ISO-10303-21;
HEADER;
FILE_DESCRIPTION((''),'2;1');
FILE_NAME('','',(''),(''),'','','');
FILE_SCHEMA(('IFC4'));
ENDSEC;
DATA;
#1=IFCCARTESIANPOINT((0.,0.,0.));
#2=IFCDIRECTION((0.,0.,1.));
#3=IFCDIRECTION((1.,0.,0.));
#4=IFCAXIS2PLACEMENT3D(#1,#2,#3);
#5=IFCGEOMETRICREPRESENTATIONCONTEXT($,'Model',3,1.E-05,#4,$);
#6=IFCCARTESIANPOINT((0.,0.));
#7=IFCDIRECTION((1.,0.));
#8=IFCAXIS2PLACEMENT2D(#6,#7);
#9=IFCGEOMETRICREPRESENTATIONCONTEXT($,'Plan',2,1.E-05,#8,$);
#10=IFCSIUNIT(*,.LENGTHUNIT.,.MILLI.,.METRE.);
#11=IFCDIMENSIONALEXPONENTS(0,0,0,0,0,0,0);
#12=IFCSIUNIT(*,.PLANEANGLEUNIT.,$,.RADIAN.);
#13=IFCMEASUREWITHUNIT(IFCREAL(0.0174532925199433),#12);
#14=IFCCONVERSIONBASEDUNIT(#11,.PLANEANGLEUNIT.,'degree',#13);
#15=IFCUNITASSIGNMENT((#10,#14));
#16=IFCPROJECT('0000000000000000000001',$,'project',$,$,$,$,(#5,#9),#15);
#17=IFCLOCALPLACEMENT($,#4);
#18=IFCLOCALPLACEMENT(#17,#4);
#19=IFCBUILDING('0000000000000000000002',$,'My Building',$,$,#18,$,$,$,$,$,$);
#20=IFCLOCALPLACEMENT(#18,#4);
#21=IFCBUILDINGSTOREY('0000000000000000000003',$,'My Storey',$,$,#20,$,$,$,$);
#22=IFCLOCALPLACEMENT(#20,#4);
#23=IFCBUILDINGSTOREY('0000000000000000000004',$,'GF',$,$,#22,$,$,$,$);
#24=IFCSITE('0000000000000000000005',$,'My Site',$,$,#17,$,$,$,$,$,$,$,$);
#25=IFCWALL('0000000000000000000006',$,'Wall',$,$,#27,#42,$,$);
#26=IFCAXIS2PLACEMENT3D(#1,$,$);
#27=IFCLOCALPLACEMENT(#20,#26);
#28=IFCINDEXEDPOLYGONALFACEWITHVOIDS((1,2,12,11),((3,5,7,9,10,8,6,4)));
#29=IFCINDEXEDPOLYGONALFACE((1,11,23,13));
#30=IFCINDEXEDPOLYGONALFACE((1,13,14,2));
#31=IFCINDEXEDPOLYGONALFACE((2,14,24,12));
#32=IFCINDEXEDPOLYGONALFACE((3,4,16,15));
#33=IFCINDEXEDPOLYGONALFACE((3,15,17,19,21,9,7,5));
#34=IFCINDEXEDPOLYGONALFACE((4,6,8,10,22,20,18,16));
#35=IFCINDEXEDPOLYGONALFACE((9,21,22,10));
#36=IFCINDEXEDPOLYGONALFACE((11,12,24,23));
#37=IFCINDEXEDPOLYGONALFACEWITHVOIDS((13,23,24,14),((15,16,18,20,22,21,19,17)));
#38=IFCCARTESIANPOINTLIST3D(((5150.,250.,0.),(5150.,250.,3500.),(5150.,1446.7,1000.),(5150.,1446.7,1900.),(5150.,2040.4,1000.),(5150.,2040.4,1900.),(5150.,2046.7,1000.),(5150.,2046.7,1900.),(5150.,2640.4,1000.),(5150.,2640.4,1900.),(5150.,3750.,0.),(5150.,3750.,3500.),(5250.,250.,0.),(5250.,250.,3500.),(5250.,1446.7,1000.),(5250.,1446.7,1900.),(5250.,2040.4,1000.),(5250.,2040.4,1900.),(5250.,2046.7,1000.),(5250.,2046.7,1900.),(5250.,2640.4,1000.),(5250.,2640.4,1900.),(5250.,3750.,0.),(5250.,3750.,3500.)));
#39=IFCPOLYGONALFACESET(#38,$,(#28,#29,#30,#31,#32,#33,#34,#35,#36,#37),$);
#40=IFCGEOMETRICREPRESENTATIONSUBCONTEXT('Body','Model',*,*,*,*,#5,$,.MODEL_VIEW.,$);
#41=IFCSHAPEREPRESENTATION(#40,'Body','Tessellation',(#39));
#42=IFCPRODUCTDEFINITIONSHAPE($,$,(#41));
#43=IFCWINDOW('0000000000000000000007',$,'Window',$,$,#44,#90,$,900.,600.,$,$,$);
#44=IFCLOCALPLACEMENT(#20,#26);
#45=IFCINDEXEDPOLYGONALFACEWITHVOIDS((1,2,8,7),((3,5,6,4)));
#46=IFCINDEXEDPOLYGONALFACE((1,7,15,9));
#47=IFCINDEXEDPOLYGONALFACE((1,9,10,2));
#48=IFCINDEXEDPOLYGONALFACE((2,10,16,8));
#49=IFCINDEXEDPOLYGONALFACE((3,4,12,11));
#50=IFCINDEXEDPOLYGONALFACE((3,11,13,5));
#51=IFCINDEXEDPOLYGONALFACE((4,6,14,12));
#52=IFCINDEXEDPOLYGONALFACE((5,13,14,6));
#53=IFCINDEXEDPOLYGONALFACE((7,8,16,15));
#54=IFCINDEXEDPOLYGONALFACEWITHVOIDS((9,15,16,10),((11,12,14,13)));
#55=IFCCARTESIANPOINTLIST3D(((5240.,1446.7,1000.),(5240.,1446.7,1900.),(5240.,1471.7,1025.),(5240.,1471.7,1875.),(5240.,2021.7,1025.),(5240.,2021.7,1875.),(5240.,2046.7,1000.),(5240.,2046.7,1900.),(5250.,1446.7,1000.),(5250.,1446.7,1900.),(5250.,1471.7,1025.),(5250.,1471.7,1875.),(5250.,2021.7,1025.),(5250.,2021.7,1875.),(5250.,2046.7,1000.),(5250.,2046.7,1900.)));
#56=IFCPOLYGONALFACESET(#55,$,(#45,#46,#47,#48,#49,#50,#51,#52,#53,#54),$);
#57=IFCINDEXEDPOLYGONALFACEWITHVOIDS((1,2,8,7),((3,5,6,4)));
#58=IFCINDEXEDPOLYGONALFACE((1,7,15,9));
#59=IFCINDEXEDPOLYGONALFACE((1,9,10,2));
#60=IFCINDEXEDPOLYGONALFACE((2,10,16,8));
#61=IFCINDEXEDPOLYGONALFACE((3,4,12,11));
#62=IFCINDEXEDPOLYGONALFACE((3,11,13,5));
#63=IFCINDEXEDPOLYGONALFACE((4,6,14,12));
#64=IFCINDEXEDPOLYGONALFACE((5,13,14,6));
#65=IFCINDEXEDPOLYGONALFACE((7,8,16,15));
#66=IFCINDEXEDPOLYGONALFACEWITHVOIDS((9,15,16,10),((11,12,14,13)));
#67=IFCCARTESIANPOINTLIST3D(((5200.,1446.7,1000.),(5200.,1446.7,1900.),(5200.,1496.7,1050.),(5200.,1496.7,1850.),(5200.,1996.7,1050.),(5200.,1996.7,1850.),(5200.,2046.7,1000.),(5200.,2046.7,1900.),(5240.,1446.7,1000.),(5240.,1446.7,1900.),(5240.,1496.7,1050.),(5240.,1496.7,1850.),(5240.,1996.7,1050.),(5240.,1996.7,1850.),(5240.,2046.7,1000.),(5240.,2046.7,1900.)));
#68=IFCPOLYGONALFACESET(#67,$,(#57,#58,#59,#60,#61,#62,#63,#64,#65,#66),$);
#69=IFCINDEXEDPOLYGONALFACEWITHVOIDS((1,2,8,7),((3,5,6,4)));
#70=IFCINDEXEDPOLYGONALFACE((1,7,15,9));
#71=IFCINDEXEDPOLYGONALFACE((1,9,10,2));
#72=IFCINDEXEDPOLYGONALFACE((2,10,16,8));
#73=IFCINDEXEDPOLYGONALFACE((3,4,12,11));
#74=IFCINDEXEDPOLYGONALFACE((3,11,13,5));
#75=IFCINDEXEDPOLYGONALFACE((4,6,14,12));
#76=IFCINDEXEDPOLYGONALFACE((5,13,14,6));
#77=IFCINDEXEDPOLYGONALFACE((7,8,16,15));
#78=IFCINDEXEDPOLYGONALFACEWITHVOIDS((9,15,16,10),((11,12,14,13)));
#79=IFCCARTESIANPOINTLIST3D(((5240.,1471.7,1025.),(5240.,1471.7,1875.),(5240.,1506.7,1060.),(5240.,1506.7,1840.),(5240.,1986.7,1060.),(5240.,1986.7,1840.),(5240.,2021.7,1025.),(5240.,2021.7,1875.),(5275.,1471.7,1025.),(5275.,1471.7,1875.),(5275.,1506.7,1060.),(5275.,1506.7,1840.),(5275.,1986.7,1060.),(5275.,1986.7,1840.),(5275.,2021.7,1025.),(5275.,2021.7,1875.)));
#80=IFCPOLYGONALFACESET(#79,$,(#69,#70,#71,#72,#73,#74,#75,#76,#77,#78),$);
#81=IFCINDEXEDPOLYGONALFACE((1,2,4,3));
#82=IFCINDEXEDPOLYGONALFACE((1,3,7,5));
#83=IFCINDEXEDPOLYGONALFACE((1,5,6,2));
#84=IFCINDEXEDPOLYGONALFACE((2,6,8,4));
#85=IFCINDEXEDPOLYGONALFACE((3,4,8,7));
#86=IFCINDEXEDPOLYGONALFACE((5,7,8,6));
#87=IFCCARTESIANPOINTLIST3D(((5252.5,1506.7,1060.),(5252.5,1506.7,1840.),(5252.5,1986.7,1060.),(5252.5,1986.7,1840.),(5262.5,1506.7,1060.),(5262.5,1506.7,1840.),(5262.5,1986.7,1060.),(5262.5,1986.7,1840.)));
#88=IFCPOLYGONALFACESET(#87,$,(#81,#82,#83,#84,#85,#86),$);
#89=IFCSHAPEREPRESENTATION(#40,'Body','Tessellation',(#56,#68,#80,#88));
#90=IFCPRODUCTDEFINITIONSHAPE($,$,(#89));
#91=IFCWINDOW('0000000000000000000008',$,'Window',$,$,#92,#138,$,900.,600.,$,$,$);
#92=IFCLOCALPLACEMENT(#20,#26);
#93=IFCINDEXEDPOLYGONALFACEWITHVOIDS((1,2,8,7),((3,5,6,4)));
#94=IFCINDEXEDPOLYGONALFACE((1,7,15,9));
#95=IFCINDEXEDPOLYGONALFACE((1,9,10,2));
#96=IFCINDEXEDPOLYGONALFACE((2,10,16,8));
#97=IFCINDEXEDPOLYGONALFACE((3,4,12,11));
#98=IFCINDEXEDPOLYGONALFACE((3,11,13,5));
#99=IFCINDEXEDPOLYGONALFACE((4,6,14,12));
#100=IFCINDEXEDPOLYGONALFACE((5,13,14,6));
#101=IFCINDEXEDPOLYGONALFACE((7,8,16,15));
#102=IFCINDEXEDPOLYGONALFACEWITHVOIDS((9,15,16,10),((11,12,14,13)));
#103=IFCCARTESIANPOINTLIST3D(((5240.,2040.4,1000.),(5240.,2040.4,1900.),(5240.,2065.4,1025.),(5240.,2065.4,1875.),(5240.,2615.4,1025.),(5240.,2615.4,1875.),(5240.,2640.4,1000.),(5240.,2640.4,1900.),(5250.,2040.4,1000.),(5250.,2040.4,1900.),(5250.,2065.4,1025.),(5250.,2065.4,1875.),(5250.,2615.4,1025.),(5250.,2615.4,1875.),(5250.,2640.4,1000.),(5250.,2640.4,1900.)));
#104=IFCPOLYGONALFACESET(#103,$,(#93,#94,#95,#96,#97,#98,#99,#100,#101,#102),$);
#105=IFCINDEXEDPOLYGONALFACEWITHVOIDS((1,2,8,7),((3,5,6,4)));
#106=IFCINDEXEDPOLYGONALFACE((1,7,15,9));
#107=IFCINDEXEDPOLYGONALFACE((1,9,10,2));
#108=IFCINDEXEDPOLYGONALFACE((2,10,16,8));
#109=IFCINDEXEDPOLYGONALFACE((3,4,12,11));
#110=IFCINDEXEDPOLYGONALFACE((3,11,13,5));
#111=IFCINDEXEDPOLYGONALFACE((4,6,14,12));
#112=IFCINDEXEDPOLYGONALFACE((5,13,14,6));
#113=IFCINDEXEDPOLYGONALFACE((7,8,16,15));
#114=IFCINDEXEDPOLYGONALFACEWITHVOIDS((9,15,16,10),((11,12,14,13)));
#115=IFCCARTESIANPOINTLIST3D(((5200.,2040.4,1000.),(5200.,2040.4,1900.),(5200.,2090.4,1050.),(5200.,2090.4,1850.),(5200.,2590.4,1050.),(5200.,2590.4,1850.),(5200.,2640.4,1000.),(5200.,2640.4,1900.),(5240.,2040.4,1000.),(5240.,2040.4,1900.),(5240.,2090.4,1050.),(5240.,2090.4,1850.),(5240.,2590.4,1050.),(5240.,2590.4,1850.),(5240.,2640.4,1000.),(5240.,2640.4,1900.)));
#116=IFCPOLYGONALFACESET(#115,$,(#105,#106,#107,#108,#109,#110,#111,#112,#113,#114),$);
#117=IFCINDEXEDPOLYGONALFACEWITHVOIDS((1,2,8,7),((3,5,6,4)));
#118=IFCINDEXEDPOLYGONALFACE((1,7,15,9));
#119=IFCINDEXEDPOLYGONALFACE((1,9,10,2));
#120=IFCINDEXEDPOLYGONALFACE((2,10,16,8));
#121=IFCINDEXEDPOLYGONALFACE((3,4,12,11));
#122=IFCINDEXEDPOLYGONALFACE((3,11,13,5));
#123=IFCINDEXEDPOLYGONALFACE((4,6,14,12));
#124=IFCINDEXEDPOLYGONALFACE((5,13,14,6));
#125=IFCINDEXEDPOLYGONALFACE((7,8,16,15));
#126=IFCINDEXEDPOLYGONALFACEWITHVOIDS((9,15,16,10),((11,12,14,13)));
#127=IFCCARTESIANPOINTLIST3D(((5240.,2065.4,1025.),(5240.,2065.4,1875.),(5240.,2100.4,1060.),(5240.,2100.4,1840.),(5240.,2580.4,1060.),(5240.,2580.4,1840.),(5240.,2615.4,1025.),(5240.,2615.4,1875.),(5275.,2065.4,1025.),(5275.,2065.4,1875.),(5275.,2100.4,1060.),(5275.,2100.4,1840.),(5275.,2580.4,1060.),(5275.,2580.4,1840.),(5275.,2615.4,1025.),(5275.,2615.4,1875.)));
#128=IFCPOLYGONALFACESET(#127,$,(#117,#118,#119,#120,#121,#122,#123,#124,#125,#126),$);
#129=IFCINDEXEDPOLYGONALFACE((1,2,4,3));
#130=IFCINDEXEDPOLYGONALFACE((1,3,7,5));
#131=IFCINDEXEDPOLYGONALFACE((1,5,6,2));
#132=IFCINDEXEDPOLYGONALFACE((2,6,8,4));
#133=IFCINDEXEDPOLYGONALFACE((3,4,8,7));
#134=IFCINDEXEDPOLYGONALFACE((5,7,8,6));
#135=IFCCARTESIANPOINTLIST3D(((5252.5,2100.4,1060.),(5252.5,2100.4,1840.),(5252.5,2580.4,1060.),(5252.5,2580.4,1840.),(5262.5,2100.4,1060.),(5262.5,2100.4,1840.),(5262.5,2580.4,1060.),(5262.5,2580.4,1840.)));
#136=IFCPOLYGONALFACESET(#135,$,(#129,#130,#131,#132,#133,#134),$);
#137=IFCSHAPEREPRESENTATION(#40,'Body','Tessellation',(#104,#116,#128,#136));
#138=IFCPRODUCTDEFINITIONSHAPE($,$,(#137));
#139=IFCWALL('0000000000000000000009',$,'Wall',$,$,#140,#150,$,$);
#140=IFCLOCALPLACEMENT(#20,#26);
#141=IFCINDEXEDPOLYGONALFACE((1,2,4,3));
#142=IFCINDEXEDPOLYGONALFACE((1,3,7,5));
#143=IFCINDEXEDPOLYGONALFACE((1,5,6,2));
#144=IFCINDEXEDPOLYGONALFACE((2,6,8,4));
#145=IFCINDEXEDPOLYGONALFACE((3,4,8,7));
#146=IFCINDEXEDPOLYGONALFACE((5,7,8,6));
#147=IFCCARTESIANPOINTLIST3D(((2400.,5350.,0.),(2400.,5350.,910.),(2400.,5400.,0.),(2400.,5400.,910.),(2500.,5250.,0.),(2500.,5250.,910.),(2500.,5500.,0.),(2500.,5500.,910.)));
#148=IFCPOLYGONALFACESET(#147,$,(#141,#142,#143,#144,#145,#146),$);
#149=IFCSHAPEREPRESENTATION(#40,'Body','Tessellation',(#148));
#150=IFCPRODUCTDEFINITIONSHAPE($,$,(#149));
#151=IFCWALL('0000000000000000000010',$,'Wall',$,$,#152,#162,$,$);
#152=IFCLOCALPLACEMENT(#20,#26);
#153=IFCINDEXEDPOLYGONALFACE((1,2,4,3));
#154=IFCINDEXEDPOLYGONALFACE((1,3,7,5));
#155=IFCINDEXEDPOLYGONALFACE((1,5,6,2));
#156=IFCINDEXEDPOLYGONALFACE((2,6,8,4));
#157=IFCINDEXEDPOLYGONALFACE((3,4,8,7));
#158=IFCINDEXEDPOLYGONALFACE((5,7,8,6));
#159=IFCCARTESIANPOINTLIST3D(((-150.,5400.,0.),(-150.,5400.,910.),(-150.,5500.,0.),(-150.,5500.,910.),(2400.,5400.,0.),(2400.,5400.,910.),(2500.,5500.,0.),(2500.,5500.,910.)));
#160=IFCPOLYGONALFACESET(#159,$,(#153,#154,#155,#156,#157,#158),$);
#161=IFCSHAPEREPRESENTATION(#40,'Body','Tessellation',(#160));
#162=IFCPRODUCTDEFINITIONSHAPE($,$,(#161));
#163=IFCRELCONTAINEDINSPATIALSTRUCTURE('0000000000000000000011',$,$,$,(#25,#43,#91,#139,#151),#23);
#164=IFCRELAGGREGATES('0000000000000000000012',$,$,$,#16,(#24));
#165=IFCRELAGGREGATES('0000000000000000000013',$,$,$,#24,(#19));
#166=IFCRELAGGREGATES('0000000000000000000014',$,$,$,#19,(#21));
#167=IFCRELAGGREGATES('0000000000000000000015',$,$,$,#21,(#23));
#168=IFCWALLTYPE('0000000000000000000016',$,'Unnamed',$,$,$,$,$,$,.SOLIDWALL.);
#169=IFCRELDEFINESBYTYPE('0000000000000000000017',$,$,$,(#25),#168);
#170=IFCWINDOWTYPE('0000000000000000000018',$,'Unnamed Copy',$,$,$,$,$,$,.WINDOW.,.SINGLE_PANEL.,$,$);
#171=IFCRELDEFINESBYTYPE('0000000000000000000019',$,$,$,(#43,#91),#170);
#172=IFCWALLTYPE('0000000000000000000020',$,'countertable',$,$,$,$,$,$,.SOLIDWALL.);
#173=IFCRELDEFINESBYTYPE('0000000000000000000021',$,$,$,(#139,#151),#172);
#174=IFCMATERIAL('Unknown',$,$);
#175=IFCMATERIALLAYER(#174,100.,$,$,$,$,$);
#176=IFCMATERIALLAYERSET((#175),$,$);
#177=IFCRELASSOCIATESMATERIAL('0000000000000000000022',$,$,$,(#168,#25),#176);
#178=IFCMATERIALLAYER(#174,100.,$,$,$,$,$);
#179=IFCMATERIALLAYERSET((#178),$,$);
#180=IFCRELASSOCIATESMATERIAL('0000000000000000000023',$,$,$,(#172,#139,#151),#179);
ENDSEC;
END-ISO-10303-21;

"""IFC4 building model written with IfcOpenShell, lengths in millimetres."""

from ifc_helpers import new_model, entity, si_unit, converted_unit, frame, origin_with_axes, origin_2d_with_axis, place, context, subcontext, project, spatial, line, indexed_curve, outline, extrude, shape, source, transform, mapped, material, layer, layer_set, layer_usage, type_object, type_shapes, element, fill, save


model = new_model("IFC4")

# Units and contexts
model_context = context("Model", 3, precision=1e-05, world=origin_with_axes())
plan_context = context("Plan", 2, precision=1e-05, world=origin_2d_with_axis())
body_context_1 = subcontext(model_context, "Body", "Model", "MODEL_VIEW")
body_context_2 = subcontext(plan_context, "Body", "Plan", "PLAN_VIEW")
ifc_project = project(units=[si_unit("LENGTHUNIT", "METRE", prefix="MILLI"), converted_unit("PLANEANGLEUNIT", "degree", entity("IfcReal", 0.0174532925199433), si_unit("PLANEANGLEUNIT", "RADIAN"), dimensions=[0, 0, 0, 0, 0, 0, 0])], contexts=[model_context, plan_context])

# Site, building, storeys
site_placement = place(None, origin_with_axes())
site = spatial("IfcSite", under=ifc_project, at=site_placement, Name="My Site")
building_placement = place(site_placement, origin_with_axes())
building = spatial("IfcBuilding", under=site, at=building_placement, Name="My Building")
storey_1_placement = place(building_placement, origin_with_axes())
storey_1 = spatial("IfcBuildingStorey", under=building, at=storey_1_placement, Name="My Storey")
storey_2_placement = place(storey_1_placement, origin_with_axes())
storey_2 = spatial("IfcBuildingStorey", under=storey_1, at=storey_2_placement, Name="GF")

# Shared definitions
ifc_material = material(Name="Unknown")
ifc_layer_1 = layer(ifc_material, 100.0)
ifc_layer_set_1 = layer_set([ifc_layer_1])
wall_type_1 = type_object("IfcWallType", Name="Unnamed", PredefinedType="SOLIDWALL", material=ifc_layer_set_1)

# Shared definitions
shared_shape_1 = source(origin_with_axes(), body_context_1, "Body", "SweptSolid", [
    extrude(outline(indexed_curve([(0.0, 0.0), (600.0, 0.0), (600.0, 900.0), (0.0, 900.0)], segments=[line(1, 2, 3, 4, 1)])), frame((0.0, -600.0, 0.0), z_axis=(0.0, -1.0, 0.0), x_axis=(1.0, 0.0, 0.0)), (0.0, 0.0, -1.0), 1200.0),
])
window_type_1 = type_object("IfcWindowType", Name="Unnamed Copy", PartitioningType="SINGLE_PANEL", PredefinedType="WINDOW")
shared_shape_2 = source(origin_with_axes(), body_context_1, "Body", "SweptSolid", [
    extrude(outline(indexed_curve([(0.0, 0.0), (600.0, 0.0), (600.0, 900.0), (0.0, 900.0)], segments=[line(1, 2, 3, 4, 1)]), holes=[indexed_curve([(25.0, 25.0), (575.0, 25.0), (575.0, 875.0), (25.0, 875.0)], segments=[line(1, 2, 3, 4, 1)])]), frame((0.0, 90.0, 0.0), z_axis=(0.0, -1.0, 0.0), x_axis=(1.0, 0.0, 0.0)), (0.0, 0.0, -1.0), 10.0),
    extrude(outline(indexed_curve([(0.0, 0.0), (600.0, 0.0), (600.0, 900.0), (0.0, 900.0)], segments=[line(1, 2, 3, 4, 1)]), holes=[indexed_curve([(50.0, 50.0), (550.0, 50.0), (550.0, 850.0), (50.0, 850.0)], segments=[line(1, 2, 3, 4, 1)])]), frame((0.0, 50.0, 0.0), z_axis=(0.0, -1.0, 0.0), x_axis=(1.0, 0.0, 0.0)), (0.0, 0.0, -1.0), 40.0),
    extrude(outline(indexed_curve([(0.0, 0.0), (550.0, 0.0), (550.0, 850.0), (0.0, 850.0)], segments=[line(1, 2, 3, 4, 1)]), holes=[indexed_curve([(35.0, 35.0), (515.0, 35.0), (515.0, 815.0), (35.0, 815.0)], segments=[line(1, 2, 3, 4, 1)])]), frame((25.0, 90.0, 25.0), z_axis=(0.0, -1.0, 0.0), x_axis=(1.0, 0.0, 0.0)), (0.0, 0.0, -1.0), 35.0),
    extrude(outline(indexed_curve([(35.0, 35.0), (515.0, 35.0), (515.0, 815.0), (35.0, 815.0)], segments=[line(1, 2, 3, 4, 1)])), frame((25.0, 102.5, 25.0), z_axis=(0.0, -1.0, 0.0), x_axis=(1.0, 0.0, 0.0)), (0.0, 0.0, -1.0), 10.0),
])
shared_shape_3 = source(origin_with_axes(), body_context_2, "Body", "Curve2D", [
    entity("IfcIndexedPolyCurve", entity("IfcCartesianPointList2D", [[50.0, 50.0], [550.0, 50.0]])),
    entity("IfcIndexedPolyCurve", entity("IfcCartesianPointList2D", [[0.0, 100.0], [25.0, 100.0], [25.0, 90.0], [50.0, 90.0], [50.0, 50.0], [0.0, 50.0]]), [entity("IfcLineIndex", [1, 2, 3, 4, 5, 6, 1])]),
    entity("IfcIndexedPolyCurve", entity("IfcCartesianPointList2D", [[600.0, 100.0], [575.0, 100.0], [575.0, 90.0], [550.0, 90.0], [550.0, 50.0], [600.0, 50.0]]), [entity("IfcLineIndex", [1, 2, 3, 4, 5, 6, 1])]),
    entity("IfcIndexedPolyCurve", entity("IfcCartesianPointList2D", [[25.0, 90.0], [60.0, 90.0], [60.0, 125.0], [25.0, 125.0]]), [entity("IfcLineIndex", [1, 2, 3, 4, 1])]),
    entity("IfcIndexedPolyCurve", entity("IfcCartesianPointList2D", [[575.0, 90.0], [540.0, 90.0], [540.0, 125.0], [575.0, 125.0]]), [entity("IfcLineIndex", [1, 2, 3, 4, 1])]),
    entity("IfcIndexedPolyCurve", entity("IfcCartesianPointList2D", [[60.0, 90.0], [540.0, 90.0]])),
    entity("IfcIndexedPolyCurve", entity("IfcCartesianPointList2D", [[60.0, 125.0], [540.0, 125.0]])),
    entity("IfcIndexedPolyCurve", entity("IfcCartesianPointList2D", [[60.0, 107.5], [540.0, 107.5]])),
])
type_shapes(window_type_1, [shared_shape_2, shared_shape_3])

# Wall, openings, windows
ifc_layer_usage_1 = layer_usage(ifc_layer_set_1, "AXIS2", "POSITIVE", 0.0)
wall_1_placement = place(storey_2_placement, frame((5150.0, 3750.0, 0.0), z_axis=(0.0, 0.0, 1.0), x_axis=(0.0, -1.0, 0.0)))
wall_1 = element("IfcWall", 1, at=wall_1_placement, inside=storey_2, type_object=wall_type_1, material=ifc_layer_usage_1, Name="Wall", context=body_context_1, shape_type="SweptSolid", body=[
    extrude(outline(indexed_curve([(0.0, 0.0), (0.0, 100.0), (3500.0, 100.0), (3500.0, 0.0)], segments=[line(1, 2, 3, 4, 1)])), origin_with_axes(), (0.0, 0.0, 1.0), 3500.0),
])
opening_1_placement = place(wall_1_placement, frame((1703.3, 0.0, 1000.0), z_axis=(0.0, 0.0, 1.0), x_axis=(1.0, 0.0, 0.0)))
opening_1 = element("IfcOpeningElement", 2, at=opening_1_placement, cuts=wall_1, PredefinedType="OPENING", context=body_context_1, shape_type="MappedRepresentation", body=[
    mapped(shared_shape_1, transform((0.0, 0.0, 0.0), x_axis=(1.0, 0.0, 0.0), y_axis=(0.0, 1.0, 0.0), z_axis=(0.0, 0.0, 1.0), scale=1.0)),
])
opening_2_placement = place(wall_1_placement, frame((1109.6, 0.0, 1000.0), z_axis=(0.0, 0.0, 1.0), x_axis=(1.0, 0.0, 0.0)))
opening_2 = element("IfcOpeningElement", 3, at=opening_2_placement, cuts=wall_1, PredefinedType="OPENING", context=body_context_1, shape_type="MappedRepresentation", body=[
    mapped(shared_shape_1, transform((0.0, 0.0, 0.0), x_axis=(1.0, 0.0, 0.0), y_axis=(0.0, 1.0, 0.0), z_axis=(0.0, 0.0, 1.0), scale=1.0)),
])
window_1_placement = place(opening_1_placement, origin_with_axes())
window_1 = element("IfcWindow", 4, at=window_1_placement, inside=storey_2, type_object=window_type_1, Name="Window", OverallHeight=900.0, OverallWidth=600.0, shapes=[
    shape(body_context_1, "Body", "MappedRepresentation", [mapped(shared_shape_2, transform((0.0, 0.0, 0.0), x_axis=(1.0, 0.0, 0.0), y_axis=(0.0, 1.0, 0.0), z_axis=(0.0, 0.0, 1.0), scale=1.0))]),
    shape(body_context_2, "Body", "MappedRepresentation", [mapped(shared_shape_3, transform((0.0, 0.0, 0.0), x_axis=(1.0, 0.0, 0.0), y_axis=(0.0, 1.0, 0.0), z_axis=(0.0, 0.0, 1.0), scale=1.0))]),
])
fill(opening_1, window_1)
window_2_placement = place(opening_2_placement, frame((0.0, 0.0, 0.0), z_axis=(0.0, 0.0, 1.0), x_axis=(1.0, 0.0, 0.0)))
window_2 = element("IfcWindow", 5, at=window_2_placement, inside=storey_2, type_object=window_type_1, Name="Window", OverallHeight=900.0, OverallWidth=600.0, shapes=[
    shape(body_context_1, "Body", "MappedRepresentation", [mapped(shared_shape_2, transform((0.0, 0.0, 0.0), x_axis=(1.0, 0.0, 0.0), y_axis=(0.0, 1.0, 0.0), z_axis=(0.0, 0.0, 1.0), scale=1.0))]),
    shape(body_context_2, "Body", "MappedRepresentation", [mapped(shared_shape_3, transform((0.0, 0.0, 0.0), x_axis=(1.0, 0.0, 0.0), y_axis=(0.0, 1.0, 0.0), z_axis=(0.0, 0.0, 1.0), scale=1.0))]),
])
fill(opening_2, window_2)

# Walls
ifc_layer_2 = layer(ifc_material, 100.0)
ifc_layer_set_2 = layer_set([ifc_layer_2])
ifc_layer_usage_2 = layer_usage(ifc_layer_set_2, "AXIS2", "POSITIVE", 0.0)
wall_type_2 = type_object("IfcWallType", Name="countertable", PredefinedType="SOLIDWALL", material=ifc_layer_set_2)
wall_2_placement = place(storey_2_placement, frame((2500.0, 5250.0, 0.0), z_axis=(0.0, 0.0, 1.0), x_axis=(0.0, 1.0, 0.0)))
element("IfcWall", 6, at=wall_2_placement, inside=storey_2, type_object=wall_type_2, material=ifc_layer_usage_2, Name="Wall", context=body_context_1, shape_type="SweptSolid", body=[
    extrude(outline(indexed_curve([(0.0, 0.0), (100.0, 100.0), (150.0, 100.0), (250.0, 0.0)], segments=[line(1, 2, 3, 4, 1)])), origin_with_axes(), (0.0, 0.0, 1.0), 910.0),
])
ifc_layer_usage_3 = layer_usage(ifc_layer_set_2, "AXIS2", "POSITIVE", 0.0)
wall_3_placement = place(storey_2_placement, frame((2500.0, 5500.0, 0.0), z_axis=(0.0, 0.0, 1.0), x_axis=(-1.0, 0.0, 0.0)))
element("IfcWall", 7, at=wall_3_placement, inside=storey_2, type_object=wall_type_2, material=ifc_layer_usage_3, Name="Wall", context=body_context_1, shape_type="SweptSolid", body=[
    extrude(outline(indexed_curve([(0.0, 0.0), (100.0, 100.0), (2650.0, 100.0), (2650.0, 0.0)], segments=[line(1, 2, 3, 4, 1)])), origin_with_axes(), (0.0, 0.0, 1.0), 910.0),
])

save(model, "model.ifc")
